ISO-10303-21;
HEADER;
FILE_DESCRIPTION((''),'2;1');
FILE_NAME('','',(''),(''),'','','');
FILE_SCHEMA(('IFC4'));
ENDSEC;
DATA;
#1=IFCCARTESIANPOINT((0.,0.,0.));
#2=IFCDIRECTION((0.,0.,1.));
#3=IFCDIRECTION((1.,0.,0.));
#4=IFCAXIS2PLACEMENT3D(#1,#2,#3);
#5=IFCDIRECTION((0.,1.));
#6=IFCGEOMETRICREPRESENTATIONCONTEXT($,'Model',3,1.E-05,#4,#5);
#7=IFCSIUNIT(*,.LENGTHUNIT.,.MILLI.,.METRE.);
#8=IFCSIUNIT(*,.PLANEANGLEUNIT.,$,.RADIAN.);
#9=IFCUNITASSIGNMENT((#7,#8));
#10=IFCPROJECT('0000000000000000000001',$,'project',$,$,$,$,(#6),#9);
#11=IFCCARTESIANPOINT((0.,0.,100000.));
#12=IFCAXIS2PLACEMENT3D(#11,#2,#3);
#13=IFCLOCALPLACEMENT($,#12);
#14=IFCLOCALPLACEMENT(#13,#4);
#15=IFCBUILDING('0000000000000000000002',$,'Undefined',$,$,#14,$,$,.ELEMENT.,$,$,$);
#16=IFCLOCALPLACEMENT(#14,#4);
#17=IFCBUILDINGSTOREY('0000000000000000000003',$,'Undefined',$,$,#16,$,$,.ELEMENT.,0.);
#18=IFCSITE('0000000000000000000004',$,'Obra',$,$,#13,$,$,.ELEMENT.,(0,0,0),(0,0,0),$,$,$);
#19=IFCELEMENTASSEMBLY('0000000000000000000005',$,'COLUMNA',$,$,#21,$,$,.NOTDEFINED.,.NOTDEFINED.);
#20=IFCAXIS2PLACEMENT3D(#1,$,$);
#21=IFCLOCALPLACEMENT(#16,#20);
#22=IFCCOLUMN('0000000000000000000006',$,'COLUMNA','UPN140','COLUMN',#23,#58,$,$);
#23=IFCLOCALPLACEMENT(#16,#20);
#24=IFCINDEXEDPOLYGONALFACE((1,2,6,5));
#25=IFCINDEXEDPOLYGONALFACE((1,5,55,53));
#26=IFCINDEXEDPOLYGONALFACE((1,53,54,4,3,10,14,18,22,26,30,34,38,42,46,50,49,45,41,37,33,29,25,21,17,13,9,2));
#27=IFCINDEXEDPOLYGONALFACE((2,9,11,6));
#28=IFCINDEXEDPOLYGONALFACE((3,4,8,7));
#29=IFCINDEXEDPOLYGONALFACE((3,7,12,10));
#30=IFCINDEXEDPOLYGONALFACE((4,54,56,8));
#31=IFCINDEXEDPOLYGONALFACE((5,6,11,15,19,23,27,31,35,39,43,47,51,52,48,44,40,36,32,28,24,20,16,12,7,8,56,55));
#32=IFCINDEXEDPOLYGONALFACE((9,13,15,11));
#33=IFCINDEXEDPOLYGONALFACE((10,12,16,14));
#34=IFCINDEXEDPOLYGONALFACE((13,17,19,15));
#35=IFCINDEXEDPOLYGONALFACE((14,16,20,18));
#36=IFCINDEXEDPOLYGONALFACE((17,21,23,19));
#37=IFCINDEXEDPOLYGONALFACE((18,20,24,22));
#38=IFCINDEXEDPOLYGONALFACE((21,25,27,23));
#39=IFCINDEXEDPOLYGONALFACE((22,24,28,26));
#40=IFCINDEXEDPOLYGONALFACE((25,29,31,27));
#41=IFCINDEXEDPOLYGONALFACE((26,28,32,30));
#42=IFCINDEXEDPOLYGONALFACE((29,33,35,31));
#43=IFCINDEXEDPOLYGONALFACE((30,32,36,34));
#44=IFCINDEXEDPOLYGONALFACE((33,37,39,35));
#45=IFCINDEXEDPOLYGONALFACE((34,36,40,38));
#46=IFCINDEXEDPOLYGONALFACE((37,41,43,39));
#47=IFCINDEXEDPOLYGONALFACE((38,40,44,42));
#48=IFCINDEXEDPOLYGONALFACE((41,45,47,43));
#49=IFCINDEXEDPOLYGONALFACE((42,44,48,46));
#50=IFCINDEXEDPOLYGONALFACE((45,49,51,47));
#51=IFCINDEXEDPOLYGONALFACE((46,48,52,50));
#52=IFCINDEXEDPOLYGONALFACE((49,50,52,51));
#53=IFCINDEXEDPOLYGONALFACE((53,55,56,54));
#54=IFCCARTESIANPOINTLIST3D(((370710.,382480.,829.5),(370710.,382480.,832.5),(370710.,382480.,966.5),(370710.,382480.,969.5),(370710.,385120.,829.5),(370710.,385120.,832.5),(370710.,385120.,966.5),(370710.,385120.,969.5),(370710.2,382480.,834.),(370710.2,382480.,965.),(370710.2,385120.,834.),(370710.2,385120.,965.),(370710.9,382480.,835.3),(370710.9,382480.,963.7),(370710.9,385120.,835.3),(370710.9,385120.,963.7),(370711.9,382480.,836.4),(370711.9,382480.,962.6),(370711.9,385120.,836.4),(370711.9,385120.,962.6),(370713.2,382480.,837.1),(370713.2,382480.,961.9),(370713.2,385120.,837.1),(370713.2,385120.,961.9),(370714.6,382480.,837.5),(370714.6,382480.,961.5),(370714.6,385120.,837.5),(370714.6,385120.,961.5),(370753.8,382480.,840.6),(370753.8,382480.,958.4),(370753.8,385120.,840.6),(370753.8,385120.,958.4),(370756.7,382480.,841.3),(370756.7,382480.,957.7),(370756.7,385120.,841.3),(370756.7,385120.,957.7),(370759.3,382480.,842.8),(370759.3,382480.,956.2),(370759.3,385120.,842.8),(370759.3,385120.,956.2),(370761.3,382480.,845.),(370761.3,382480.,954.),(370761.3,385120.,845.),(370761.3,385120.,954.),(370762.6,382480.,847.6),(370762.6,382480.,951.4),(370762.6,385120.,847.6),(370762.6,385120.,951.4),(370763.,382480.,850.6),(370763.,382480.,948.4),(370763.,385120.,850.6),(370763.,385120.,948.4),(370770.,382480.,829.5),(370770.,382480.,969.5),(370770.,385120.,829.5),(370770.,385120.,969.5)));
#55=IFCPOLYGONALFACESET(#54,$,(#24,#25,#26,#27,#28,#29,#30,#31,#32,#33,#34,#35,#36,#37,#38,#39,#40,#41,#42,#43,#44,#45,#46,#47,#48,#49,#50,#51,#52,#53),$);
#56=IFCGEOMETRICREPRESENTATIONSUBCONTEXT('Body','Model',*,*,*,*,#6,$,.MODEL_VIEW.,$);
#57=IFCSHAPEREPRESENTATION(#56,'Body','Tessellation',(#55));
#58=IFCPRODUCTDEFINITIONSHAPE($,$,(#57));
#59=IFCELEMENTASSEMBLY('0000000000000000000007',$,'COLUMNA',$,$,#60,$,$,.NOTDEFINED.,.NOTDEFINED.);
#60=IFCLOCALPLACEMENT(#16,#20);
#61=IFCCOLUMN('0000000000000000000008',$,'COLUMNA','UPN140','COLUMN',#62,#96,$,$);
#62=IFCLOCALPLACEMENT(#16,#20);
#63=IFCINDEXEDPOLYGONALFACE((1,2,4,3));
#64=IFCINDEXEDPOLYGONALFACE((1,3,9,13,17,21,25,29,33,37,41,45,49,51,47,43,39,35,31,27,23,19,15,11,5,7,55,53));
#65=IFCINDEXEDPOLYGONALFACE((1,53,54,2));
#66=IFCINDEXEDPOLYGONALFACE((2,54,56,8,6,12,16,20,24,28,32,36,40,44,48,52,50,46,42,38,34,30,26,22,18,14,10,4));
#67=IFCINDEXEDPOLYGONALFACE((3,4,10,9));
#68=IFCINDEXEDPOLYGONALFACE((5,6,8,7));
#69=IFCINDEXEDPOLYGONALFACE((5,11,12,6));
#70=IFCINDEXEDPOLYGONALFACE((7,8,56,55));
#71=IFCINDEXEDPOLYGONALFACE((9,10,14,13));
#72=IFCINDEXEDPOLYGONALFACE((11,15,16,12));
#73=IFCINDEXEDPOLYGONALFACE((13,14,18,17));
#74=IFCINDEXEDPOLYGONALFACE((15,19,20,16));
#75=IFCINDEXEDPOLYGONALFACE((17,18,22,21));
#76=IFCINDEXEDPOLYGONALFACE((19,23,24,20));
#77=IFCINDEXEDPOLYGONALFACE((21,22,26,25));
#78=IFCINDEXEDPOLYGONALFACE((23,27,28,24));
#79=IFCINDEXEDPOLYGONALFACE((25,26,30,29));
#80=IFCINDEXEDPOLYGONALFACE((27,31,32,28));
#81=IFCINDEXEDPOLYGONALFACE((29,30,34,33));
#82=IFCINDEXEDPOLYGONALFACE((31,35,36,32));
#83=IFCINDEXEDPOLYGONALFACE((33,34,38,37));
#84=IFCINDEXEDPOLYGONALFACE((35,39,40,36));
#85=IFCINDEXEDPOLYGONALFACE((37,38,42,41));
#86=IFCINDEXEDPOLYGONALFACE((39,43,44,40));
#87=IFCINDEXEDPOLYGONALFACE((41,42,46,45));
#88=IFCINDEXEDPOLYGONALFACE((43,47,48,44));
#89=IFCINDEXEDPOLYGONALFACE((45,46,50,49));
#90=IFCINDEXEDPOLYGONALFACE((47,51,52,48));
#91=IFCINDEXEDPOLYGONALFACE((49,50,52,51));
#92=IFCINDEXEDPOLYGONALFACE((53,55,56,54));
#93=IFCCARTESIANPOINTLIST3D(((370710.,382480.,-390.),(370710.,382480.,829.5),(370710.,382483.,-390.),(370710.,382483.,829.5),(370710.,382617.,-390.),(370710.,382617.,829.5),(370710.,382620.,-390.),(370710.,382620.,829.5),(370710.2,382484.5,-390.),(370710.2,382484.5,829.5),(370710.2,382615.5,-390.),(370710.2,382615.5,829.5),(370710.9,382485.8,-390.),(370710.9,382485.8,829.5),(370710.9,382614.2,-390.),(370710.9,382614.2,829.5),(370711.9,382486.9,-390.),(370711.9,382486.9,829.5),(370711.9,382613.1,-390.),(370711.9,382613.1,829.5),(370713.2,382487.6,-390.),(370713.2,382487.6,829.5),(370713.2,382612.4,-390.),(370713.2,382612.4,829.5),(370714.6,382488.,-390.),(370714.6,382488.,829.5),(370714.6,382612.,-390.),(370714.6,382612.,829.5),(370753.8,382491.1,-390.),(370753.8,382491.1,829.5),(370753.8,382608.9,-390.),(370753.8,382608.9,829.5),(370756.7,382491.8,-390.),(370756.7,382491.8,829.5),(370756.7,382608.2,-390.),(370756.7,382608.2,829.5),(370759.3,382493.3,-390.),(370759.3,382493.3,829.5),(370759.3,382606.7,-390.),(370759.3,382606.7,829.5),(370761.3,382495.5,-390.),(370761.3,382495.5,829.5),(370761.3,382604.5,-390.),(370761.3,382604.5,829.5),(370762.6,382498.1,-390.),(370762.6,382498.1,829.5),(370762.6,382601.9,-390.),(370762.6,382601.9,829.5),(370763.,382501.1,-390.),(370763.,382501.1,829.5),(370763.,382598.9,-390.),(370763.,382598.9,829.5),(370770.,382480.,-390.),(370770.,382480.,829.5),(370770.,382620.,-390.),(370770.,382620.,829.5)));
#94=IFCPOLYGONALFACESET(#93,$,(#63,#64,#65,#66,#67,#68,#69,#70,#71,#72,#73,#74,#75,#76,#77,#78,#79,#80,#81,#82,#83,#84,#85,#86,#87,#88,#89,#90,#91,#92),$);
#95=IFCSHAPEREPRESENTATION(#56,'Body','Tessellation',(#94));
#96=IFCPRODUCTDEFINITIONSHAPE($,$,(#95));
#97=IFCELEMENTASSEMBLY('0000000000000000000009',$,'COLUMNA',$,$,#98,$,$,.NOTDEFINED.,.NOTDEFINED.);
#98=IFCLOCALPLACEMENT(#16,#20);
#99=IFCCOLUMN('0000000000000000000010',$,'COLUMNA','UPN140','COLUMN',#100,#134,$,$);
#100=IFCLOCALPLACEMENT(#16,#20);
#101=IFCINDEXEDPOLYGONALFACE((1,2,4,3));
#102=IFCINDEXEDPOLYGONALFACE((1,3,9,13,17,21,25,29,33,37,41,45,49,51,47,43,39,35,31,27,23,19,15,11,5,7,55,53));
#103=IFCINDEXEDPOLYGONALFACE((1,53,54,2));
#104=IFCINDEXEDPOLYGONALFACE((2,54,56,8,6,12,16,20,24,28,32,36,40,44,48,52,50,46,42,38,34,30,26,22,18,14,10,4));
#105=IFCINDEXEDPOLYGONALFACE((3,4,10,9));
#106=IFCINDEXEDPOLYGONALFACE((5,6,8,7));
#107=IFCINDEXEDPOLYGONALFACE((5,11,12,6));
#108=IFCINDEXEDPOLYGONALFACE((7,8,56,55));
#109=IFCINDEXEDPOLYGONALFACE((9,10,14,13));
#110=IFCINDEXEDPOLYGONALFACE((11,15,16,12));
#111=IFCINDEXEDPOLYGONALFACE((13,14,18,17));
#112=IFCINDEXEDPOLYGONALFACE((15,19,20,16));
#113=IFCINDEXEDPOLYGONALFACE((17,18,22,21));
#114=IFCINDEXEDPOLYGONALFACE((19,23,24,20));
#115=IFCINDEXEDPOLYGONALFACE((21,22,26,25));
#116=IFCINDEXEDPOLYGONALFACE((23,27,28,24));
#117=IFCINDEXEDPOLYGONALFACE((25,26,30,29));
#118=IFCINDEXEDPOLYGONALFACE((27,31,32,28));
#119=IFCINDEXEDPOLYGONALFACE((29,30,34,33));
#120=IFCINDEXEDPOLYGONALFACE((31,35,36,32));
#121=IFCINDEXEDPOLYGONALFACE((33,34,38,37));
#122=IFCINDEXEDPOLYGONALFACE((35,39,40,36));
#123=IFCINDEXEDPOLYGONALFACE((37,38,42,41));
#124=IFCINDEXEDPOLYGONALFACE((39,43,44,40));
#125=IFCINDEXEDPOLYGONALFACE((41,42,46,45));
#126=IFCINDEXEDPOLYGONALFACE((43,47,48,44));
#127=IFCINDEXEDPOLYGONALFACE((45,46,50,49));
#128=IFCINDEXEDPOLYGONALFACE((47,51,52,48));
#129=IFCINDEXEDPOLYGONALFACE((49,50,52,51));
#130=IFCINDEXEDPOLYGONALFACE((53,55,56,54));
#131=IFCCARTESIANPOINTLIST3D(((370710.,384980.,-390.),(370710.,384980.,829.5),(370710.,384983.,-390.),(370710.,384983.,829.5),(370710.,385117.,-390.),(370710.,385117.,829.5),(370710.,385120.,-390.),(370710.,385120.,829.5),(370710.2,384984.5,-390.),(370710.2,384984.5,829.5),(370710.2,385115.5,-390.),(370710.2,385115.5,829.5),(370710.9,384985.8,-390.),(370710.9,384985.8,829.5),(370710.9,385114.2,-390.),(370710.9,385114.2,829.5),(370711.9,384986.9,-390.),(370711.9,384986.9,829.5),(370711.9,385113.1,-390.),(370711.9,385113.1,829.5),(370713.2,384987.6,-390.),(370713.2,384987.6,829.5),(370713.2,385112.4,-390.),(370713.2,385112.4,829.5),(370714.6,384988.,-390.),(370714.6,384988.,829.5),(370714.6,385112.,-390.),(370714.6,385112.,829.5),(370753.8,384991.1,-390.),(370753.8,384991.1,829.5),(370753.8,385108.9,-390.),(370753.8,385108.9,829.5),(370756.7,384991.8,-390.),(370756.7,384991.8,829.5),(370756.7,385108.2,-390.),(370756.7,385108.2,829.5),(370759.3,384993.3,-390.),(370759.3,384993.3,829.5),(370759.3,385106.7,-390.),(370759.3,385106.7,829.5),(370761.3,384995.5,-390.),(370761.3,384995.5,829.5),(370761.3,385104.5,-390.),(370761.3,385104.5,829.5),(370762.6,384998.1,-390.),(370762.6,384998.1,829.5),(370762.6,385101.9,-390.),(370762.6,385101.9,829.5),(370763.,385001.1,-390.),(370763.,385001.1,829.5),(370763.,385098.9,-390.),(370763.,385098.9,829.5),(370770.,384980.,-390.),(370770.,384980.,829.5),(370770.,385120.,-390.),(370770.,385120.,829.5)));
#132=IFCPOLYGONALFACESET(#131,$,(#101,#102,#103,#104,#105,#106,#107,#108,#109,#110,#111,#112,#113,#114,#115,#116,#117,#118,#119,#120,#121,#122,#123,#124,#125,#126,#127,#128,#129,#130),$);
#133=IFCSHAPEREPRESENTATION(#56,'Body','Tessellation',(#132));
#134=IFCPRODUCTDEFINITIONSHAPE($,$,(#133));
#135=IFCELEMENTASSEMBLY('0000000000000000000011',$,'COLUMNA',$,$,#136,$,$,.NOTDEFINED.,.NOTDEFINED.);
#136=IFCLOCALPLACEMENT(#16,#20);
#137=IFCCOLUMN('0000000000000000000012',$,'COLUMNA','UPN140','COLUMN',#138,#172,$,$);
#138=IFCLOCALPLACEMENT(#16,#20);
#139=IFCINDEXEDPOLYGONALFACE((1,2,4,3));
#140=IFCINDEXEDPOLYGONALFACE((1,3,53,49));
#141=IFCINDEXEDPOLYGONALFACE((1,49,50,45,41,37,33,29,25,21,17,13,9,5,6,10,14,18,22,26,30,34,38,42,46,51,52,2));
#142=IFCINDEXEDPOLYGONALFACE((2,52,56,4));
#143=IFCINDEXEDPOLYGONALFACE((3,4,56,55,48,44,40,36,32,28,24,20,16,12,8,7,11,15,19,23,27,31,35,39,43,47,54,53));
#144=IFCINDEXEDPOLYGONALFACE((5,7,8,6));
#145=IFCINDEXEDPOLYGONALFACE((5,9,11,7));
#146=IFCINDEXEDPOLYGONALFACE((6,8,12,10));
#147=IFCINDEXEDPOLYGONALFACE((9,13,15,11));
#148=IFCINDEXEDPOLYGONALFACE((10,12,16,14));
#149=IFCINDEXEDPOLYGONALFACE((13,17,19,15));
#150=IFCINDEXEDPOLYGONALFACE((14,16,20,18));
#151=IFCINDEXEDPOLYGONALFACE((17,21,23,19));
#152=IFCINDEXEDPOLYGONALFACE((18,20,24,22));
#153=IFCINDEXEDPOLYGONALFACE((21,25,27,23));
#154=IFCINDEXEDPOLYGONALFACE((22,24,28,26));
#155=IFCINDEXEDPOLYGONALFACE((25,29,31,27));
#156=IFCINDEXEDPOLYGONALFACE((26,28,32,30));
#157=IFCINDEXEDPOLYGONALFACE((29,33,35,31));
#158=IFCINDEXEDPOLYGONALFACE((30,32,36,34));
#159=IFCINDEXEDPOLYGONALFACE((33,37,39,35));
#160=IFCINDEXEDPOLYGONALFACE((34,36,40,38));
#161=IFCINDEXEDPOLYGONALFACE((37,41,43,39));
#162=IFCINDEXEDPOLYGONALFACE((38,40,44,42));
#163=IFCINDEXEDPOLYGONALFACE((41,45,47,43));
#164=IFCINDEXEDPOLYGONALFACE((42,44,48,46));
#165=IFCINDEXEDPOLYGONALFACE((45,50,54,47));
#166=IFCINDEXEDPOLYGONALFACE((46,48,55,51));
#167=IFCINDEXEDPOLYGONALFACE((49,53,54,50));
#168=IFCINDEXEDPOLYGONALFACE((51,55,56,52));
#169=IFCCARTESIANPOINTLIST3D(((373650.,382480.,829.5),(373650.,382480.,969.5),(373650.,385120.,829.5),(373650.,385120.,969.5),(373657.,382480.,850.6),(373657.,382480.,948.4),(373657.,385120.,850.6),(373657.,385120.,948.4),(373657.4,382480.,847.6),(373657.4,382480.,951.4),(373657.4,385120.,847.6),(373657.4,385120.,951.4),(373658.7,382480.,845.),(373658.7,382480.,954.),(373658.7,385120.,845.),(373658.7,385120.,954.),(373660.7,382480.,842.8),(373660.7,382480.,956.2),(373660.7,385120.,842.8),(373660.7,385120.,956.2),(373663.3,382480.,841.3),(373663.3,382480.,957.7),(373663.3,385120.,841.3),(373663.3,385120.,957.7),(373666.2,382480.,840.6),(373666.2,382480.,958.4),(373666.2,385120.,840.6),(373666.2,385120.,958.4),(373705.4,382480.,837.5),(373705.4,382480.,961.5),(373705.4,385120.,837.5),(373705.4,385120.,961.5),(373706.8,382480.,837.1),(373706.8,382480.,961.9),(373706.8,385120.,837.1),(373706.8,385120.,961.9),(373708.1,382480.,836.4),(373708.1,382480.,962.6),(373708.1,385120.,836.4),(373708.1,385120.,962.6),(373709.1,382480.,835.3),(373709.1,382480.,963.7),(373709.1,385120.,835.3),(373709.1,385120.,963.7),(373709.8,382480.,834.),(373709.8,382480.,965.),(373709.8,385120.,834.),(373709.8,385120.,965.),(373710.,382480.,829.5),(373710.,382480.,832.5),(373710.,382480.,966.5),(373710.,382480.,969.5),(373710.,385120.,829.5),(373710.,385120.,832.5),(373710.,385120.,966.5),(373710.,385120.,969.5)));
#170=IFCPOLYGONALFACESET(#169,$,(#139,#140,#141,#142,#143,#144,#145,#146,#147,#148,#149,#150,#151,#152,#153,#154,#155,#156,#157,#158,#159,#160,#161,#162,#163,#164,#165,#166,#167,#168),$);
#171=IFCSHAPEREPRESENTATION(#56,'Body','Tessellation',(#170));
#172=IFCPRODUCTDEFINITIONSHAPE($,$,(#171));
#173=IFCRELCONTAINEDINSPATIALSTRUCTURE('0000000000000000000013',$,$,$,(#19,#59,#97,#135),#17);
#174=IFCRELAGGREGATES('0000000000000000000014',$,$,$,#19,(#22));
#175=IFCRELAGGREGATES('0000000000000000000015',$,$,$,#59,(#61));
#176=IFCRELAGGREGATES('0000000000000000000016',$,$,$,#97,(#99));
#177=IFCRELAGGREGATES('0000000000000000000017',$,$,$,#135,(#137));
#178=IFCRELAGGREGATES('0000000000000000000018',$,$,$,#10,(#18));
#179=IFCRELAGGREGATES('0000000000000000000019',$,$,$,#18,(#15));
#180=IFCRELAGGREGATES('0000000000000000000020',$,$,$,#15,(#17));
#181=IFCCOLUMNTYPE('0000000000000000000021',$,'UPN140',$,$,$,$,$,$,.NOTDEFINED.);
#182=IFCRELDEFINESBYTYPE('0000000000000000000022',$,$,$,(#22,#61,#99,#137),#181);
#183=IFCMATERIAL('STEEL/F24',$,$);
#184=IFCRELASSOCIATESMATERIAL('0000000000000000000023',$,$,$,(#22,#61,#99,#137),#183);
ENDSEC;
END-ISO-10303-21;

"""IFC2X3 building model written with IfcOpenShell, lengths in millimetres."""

from ifc_helpers import new_model, si_unit, direction, frame, origin_with_axes, origin_2d_with_axis, place, context, subcontext, project, spatial, u_section, extrude, material, type_object, element, aggregate, save


model = new_model("IFC2X3")

# Units and contexts
model_context = context("Model", 3, precision=1e-05, world=origin_with_axes(), true_north=direction((0.0, 1.0)))
body_context = subcontext(model_context, "Body", "Model", "MODEL_VIEW")
ifc_project = project(units=[si_unit("LENGTHUNIT", "METRE", prefix="MILLI"), si_unit("PLANEANGLEUNIT", "RADIAN")], contexts=[model_context])

# Site, building, storey
site_placement = place(None, frame((0.0, 0.0, 100000.0), z_axis=(0.0, 0.0, 1.0), x_axis=(1.0, 0.0, 0.0)))
site = spatial("IfcSite", under=ifc_project, at=site_placement, Name="Obra", CompositionType="ELEMENT", RefLatitude=(0, 0, 0), RefLongitude=(0, 0, 0))
building_placement = place(site_placement, origin_with_axes())
building = spatial("IfcBuilding", under=site, at=building_placement, Name="Undefined", CompositionType="ELEMENT")
storey_placement = place(building_placement, origin_with_axes())
storey = spatial("IfcBuildingStorey", under=building, at=storey_placement, Name="Undefined", CompositionType="ELEMENT", Elevation=0.0)

# Element assemblies, columns
assembly_1_placement = place(storey_placement, origin_with_axes())
assembly_1 = element("IfcElementAssembly", 1, at=assembly_1_placement, inside=storey, Name="COLUMNA", AssemblyPlace="NOTDEFINED", PredefinedType="NOTDEFINED")
ifc_material_1 = material(Name="STEEL/F24")
column_type_1 = type_object("IfcColumnType", Name="UPN140", PredefinedType="NOTDEFINED")
column_1_placement = place(assembly_1_placement, frame((370740.0, 385120.0, 899.5), z_axis=(0.0, -1.0, 0.0), x_axis=(0.0, 0.0, 1.0)))
column_1 = element("IfcColumn", 2, at=column_1_placement, type_object=column_type_1, material=ifc_material_1, Name="COLUMNA", Description="UPN140", ObjectType="COLUMN", context=body_context, shape_type="SweptSolid", body=[
    extrude(u_section(Depth=140.0, FlangeWidth=60.0, WebThickness=7.0, FlangeThickness=10.0, FilletRadius=10.0, EdgeRadius=5.0, FlangeSlope=0.07983, at=origin_2d_with_axis()), frame((0.0, 0.0, 2640.0), z_axis=(0.0, 0.0, -1.0), x_axis=(0.0, 1.0, 0.0)), (0.0, 0.0, 1.0), 2640.0),
])
aggregate(assembly_1, [column_1])
assembly_2_placement = place(storey_placement, origin_with_axes())
assembly_2 = element("IfcElementAssembly", 3, at=assembly_2_placement, inside=storey, Name="COLUMNA", AssemblyPlace="NOTDEFINED", PredefinedType="NOTDEFINED")
column_2_placement = place(assembly_2_placement, frame((370740.0, 382550.0, -390.0), z_axis=(0.0, 0.0, 1.0), x_axis=(0.0, 1.0, 0.0)))
column_2 = element("IfcColumn", 4, at=column_2_placement, type_object=column_type_1, material=ifc_material_1, Name="COLUMNA", Description="UPN140", ObjectType="COLUMN", context=body_context, shape_type="SweptSolid", body=[
    extrude(u_section(Depth=140.0, FlangeWidth=60.0, WebThickness=7.0, FlangeThickness=10.0, FilletRadius=10.0, EdgeRadius=5.0, FlangeSlope=0.07983, at=origin_2d_with_axis()), frame((0.0, 0.0, 1219.5), z_axis=(0.0, 0.0, -1.0), x_axis=(0.0, 1.0, 0.0)), (0.0, 0.0, 1.0), 1219.5),
])
aggregate(assembly_2, [column_2])
assembly_3_placement = place(storey_placement, origin_with_axes())
assembly_3 = element("IfcElementAssembly", 5, at=assembly_3_placement, inside=storey, Name="COLUMNA", AssemblyPlace="NOTDEFINED", PredefinedType="NOTDEFINED")
column_3_placement = place(assembly_3_placement, frame((370740.0, 385050.0, -390.0), z_axis=(0.0, 0.0, 1.0), x_axis=(0.0, 1.0, 0.0)))
column_3 = element("IfcColumn", 6, at=column_3_placement, type_object=column_type_1, material=ifc_material_1, Name="COLUMNA", Description="UPN140", ObjectType="COLUMN", context=body_context, shape_type="SweptSolid", body=[
    extrude(u_section(Depth=140.0, FlangeWidth=60.0, WebThickness=7.0, FlangeThickness=10.0, FilletRadius=10.0, EdgeRadius=5.0, FlangeSlope=0.07983, at=origin_2d_with_axis()), frame((0.0, 0.0, 1219.5), z_axis=(0.0, 0.0, -1.0), x_axis=(0.0, 1.0, 0.0)), (0.0, 0.0, 1.0), 1219.5),
])
aggregate(assembly_3, [column_3])
assembly_4_placement = place(storey_placement, origin_with_axes())
assembly_4 = element("IfcElementAssembly", 7, at=assembly_4_placement, inside=storey, Name="COLUMNA", AssemblyPlace="NOTDEFINED", PredefinedType="NOTDEFINED")
column_4_placement = place(assembly_4_placement, frame((373680.0, 385120.0, 899.5), z_axis=(0.0, -1.0, 0.0), x_axis=(0.0, 0.0, -1.0)))
column_4 = element("IfcColumn", 8, at=column_4_placement, type_object=column_type_1, material=ifc_material_1, Name="COLUMNA", Description="UPN140", ObjectType="COLUMN", context=body_context, shape_type="SweptSolid", body=[
    extrude(u_section(Depth=140.0, FlangeWidth=60.0, WebThickness=7.0, FlangeThickness=10.0, FilletRadius=10.0, EdgeRadius=5.0, FlangeSlope=0.07983, at=origin_2d_with_axis()), frame((0.0, 0.0, 2640.0), z_axis=(0.0, 0.0, -1.0), x_axis=(0.0, 1.0, 0.0)), (0.0, 0.0, 1.0), 2640.0),
])
aggregate(assembly_4, [column_4])

save(model, "model.ifc")
